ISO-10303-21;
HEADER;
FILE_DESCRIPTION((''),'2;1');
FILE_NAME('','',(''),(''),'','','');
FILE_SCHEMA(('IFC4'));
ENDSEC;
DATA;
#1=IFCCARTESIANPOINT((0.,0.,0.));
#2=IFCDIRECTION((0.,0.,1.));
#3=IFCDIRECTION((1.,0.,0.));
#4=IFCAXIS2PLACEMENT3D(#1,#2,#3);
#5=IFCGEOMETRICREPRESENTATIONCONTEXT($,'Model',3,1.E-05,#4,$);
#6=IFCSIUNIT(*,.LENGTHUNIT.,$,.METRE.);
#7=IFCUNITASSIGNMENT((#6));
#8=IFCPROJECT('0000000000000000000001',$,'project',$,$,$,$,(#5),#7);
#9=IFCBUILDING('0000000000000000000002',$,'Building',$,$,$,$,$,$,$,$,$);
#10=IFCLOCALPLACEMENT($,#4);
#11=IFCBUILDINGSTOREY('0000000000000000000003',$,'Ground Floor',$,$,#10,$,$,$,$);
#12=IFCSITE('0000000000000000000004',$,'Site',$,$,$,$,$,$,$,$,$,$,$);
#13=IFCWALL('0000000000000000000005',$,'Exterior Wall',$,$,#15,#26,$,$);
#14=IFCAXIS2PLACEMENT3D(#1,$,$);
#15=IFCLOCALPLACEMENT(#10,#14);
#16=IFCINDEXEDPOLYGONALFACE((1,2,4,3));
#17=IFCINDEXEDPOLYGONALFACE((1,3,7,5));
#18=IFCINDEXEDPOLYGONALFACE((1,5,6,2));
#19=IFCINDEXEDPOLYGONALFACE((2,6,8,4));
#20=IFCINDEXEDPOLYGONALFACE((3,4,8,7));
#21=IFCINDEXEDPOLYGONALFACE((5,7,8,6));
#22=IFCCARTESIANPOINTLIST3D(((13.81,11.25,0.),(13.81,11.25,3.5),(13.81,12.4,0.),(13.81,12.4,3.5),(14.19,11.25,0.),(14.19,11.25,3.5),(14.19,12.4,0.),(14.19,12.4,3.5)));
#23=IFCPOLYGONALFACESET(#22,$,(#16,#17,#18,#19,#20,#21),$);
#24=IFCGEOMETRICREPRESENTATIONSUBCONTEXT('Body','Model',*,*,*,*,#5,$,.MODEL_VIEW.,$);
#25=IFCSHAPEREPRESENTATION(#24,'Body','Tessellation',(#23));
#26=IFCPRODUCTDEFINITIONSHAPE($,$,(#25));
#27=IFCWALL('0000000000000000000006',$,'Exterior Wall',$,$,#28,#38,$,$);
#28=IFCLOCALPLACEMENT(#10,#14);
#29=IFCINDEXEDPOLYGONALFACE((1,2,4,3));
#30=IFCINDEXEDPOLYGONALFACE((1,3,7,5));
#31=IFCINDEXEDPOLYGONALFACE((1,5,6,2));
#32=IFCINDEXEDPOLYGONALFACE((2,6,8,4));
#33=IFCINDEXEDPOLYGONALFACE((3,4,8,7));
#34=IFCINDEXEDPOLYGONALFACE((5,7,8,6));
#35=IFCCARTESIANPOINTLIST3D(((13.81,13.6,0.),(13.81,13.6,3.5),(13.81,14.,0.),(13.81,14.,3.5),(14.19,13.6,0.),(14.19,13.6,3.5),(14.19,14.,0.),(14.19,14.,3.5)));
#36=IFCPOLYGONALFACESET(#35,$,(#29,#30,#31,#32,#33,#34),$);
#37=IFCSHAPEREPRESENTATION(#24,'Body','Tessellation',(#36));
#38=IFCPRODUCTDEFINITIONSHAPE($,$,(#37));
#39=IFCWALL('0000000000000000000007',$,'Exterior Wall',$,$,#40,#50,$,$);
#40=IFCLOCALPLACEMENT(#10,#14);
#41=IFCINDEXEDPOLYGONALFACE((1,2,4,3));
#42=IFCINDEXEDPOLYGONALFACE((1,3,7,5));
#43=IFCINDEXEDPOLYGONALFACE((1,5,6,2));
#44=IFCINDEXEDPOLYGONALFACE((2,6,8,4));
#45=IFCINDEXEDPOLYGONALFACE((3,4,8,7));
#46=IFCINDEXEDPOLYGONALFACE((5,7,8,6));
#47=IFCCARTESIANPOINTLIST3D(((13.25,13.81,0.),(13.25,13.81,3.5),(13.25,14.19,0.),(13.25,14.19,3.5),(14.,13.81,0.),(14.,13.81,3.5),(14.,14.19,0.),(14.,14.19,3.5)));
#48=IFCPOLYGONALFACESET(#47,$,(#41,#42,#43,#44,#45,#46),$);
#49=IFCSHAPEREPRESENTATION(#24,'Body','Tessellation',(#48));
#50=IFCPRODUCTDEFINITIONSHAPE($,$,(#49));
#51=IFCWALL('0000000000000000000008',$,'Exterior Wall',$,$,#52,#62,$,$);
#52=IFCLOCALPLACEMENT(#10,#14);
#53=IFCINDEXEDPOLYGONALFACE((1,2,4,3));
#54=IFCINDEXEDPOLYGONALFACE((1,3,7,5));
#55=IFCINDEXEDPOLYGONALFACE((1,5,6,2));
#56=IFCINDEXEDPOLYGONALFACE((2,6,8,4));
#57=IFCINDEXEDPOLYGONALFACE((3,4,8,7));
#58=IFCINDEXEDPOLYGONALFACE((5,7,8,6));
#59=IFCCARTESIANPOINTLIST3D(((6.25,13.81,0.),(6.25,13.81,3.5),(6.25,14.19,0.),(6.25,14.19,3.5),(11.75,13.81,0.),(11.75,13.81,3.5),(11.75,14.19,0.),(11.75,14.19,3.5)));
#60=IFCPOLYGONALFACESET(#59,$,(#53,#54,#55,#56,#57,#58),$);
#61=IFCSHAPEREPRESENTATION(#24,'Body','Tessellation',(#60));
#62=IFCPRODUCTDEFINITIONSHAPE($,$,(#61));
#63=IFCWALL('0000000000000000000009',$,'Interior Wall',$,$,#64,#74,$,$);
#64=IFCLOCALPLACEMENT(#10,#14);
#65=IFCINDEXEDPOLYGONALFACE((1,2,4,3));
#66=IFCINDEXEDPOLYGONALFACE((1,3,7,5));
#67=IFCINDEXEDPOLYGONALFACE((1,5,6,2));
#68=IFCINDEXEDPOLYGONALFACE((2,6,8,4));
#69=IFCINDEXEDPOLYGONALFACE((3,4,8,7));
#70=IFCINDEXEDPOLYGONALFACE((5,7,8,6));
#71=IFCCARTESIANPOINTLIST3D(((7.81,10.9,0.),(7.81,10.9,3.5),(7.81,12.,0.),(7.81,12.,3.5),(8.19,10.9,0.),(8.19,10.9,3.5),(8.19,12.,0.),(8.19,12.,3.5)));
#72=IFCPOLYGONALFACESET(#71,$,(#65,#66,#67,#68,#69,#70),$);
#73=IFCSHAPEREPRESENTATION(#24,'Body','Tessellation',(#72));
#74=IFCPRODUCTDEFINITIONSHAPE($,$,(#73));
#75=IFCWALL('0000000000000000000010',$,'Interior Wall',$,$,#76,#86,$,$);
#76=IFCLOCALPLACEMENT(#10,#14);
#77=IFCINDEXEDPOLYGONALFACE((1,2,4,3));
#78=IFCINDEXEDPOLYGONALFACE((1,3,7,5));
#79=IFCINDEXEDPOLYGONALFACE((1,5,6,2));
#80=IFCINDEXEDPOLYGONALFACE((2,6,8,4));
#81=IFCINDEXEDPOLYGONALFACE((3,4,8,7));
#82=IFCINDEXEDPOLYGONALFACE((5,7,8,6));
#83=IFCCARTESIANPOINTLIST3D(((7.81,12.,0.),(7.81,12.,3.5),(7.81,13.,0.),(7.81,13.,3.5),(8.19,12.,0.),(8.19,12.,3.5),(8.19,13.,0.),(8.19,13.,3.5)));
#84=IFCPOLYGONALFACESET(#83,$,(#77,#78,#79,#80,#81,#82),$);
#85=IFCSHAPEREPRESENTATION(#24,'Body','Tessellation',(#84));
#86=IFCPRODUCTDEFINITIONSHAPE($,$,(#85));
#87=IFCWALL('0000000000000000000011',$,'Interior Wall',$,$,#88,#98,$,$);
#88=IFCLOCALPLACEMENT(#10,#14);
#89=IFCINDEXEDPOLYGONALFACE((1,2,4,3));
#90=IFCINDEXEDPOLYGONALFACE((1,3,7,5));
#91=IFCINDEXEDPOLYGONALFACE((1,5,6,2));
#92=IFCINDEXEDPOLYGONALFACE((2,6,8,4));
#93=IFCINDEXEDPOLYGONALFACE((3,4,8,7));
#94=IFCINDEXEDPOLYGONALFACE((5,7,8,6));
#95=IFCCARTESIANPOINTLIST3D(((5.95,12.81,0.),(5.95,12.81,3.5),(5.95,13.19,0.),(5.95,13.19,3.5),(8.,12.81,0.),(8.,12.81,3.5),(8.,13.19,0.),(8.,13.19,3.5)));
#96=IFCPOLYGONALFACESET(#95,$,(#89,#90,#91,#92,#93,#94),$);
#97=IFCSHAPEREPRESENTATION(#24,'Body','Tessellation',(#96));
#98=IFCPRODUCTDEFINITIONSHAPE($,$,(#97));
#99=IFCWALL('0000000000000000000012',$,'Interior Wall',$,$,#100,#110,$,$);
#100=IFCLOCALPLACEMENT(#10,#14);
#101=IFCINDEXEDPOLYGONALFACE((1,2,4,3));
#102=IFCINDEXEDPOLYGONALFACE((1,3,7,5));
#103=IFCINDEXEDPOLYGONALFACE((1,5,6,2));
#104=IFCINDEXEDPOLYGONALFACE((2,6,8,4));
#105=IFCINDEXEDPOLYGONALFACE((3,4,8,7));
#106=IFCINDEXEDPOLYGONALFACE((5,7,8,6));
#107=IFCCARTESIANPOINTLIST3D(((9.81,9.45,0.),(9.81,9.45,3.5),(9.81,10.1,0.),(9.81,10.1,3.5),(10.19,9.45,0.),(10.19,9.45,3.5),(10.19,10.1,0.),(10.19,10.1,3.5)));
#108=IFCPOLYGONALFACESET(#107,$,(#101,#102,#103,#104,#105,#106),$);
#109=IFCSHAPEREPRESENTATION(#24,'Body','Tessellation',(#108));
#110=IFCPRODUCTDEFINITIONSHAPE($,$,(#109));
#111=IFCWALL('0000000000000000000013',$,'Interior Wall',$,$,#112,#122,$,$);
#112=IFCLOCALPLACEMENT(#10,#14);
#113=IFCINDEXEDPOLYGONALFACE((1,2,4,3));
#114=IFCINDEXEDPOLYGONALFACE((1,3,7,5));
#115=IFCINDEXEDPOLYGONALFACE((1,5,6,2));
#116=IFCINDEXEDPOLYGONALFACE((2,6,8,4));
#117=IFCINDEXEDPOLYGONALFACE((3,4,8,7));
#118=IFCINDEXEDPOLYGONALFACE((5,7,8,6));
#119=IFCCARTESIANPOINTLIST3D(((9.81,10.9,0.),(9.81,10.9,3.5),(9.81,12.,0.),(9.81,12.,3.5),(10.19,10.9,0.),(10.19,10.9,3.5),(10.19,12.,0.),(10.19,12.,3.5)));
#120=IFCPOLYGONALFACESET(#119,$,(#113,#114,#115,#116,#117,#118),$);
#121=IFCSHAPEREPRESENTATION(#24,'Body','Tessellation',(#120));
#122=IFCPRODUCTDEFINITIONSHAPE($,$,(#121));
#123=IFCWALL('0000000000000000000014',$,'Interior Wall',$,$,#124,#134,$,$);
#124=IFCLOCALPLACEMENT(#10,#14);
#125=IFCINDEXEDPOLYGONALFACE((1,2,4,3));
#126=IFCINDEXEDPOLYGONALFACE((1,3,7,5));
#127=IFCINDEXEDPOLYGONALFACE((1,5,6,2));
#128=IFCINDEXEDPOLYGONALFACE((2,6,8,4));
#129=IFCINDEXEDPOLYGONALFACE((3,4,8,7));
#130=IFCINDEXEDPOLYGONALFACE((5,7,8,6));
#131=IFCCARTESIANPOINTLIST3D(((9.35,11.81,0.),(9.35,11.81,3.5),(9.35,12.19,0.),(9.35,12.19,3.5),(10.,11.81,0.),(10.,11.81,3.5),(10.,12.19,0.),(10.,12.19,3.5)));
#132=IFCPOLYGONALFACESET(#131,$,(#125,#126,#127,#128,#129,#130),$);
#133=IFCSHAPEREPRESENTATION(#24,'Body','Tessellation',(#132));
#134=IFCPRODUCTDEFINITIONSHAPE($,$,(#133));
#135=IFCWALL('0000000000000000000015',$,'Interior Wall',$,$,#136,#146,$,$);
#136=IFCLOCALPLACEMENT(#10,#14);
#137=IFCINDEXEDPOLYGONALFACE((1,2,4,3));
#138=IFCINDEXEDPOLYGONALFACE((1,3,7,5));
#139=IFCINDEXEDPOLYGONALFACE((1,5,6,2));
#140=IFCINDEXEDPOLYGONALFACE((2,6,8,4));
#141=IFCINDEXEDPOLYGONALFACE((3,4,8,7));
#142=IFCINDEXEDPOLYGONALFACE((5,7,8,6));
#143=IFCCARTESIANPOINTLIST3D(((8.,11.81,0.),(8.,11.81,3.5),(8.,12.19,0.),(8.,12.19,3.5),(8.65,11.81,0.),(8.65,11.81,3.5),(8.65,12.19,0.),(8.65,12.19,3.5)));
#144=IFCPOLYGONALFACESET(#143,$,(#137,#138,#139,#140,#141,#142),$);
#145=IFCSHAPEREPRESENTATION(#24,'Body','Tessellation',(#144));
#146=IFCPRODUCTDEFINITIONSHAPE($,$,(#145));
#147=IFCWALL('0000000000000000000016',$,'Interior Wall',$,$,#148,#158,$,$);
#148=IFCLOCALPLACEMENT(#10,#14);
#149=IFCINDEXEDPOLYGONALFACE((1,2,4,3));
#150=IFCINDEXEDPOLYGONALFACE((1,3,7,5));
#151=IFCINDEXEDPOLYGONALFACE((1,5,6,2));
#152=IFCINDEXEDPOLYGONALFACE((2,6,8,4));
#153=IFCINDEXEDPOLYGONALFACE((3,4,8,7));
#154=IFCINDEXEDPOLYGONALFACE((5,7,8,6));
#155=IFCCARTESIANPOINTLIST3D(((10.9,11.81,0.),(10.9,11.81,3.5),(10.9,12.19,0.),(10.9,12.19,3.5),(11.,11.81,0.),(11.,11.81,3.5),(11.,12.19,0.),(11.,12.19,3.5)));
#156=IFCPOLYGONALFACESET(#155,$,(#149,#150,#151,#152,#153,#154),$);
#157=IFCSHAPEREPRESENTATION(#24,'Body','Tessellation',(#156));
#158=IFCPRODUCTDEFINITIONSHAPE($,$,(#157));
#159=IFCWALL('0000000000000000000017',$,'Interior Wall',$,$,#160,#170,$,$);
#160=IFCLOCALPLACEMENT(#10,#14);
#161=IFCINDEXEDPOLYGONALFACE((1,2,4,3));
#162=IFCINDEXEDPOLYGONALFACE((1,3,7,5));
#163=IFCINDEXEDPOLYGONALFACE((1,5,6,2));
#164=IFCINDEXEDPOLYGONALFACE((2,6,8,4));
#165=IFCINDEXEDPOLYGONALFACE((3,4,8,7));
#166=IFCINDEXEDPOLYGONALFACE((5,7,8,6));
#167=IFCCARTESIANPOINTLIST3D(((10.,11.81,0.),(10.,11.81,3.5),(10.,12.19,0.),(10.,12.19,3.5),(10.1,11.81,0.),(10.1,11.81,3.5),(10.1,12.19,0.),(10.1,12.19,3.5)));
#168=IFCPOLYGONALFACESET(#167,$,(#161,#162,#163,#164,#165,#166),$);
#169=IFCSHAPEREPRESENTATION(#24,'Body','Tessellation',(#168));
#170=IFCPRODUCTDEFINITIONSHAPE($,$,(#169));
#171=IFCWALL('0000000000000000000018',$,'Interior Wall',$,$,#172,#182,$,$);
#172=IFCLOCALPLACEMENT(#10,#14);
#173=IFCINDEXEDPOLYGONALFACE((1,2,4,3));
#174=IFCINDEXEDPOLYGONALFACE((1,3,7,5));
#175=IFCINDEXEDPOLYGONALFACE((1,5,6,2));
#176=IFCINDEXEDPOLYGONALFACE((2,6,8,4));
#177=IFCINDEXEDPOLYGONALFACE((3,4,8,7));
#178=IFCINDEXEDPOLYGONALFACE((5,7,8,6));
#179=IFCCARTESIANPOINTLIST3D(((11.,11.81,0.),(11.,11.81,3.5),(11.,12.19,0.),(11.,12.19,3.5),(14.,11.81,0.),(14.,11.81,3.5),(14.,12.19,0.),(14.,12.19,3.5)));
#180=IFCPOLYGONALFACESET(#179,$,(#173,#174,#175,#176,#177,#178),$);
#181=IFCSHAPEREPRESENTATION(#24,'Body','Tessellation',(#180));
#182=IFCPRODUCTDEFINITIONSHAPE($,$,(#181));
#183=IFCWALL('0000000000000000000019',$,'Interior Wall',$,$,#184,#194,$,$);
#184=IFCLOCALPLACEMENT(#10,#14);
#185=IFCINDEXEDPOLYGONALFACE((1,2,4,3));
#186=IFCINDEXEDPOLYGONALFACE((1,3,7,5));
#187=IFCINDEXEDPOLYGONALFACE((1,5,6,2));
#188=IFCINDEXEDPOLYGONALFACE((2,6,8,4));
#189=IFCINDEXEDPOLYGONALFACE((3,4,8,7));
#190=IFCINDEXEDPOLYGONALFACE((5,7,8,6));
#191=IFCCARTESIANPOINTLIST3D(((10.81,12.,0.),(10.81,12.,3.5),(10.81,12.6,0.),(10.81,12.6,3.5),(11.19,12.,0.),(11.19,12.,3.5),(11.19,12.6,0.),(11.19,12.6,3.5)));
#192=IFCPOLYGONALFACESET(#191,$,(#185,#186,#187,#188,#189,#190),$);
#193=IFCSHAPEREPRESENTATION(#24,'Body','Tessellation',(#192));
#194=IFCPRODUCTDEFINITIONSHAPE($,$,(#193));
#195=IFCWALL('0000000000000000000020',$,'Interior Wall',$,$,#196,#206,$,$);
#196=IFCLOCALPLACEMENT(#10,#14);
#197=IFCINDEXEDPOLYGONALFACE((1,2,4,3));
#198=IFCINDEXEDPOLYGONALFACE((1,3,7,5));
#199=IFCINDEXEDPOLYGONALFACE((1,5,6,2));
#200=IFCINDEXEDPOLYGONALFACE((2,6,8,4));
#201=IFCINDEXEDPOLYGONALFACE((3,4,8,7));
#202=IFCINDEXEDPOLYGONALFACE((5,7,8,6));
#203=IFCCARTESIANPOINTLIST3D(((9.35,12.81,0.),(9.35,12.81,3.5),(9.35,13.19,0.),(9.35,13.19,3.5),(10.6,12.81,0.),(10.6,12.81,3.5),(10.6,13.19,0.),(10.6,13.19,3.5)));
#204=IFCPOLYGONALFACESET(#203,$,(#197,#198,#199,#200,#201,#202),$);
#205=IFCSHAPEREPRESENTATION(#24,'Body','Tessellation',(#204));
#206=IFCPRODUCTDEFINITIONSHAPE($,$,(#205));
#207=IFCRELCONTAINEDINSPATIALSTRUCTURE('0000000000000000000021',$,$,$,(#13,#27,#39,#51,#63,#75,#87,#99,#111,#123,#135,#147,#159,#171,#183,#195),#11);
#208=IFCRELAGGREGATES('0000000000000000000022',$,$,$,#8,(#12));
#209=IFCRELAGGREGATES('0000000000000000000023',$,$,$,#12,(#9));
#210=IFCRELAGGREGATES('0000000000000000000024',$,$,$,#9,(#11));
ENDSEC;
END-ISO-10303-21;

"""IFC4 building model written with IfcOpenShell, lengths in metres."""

from ifc_helpers import new_model, si_unit, frame, origin_with_axes, place, context, subcontext, project, spatial, indexed_curve, outline, extrude, element, save


model = new_model("IFC4")

# Units and contexts
model_context = context("Model", 3, precision=1e-05, world=origin_with_axes())
body_context = subcontext(model_context, "Body", "Model", "MODEL_VIEW")
ifc_project = project(units=[si_unit("LENGTHUNIT", "METRE")], contexts=[model_context])

# Site, building, storey
site = spatial("IfcSite", under=ifc_project, Name="Site")
building = spatial("IfcBuilding", under=site, Name="Building")
storey_placement = place(None, origin_with_axes())
storey = spatial("IfcBuildingStorey", under=building, at=storey_placement, Name="Ground Floor")

# Walls
wall_1_placement = place(storey_placement, frame((14.0, 11.25, 0.0), z_axis=(0.0, 0.0, 1.0), x_axis=(0.0, 1.0, 0.0)))
element("IfcWall", 1, at=wall_1_placement, inside=storey, Name="Exterior Wall", context=body_context, shape_type="SweptSolid", body=[
    extrude(outline(indexed_curve([(0.0, 0.0), (0.0, 0.38), (1.15, 0.38), (1.15, 0.0), (0.0, 0.0)], self_intersect=False)), frame((0.0, -0.19, 0.0), z_axis=(0.0, 0.0, 1.0), x_axis=(1.0, 0.0, 0.0)), (0.0, 0.0, 1.0), 3.5),
])
wall_2_placement = place(storey_placement, frame((14.0, 13.6, 0.0), z_axis=(0.0, 0.0, 1.0), x_axis=(0.0, 1.0, 0.0)))
element("IfcWall", 2, at=wall_2_placement, inside=storey, Name="Exterior Wall", context=body_context, shape_type="SweptSolid", body=[
    extrude(outline(indexed_curve([(0.0, 0.0), (0.0, 0.38), (0.4, 0.38), (0.4, 0.0), (0.0, 0.0)], self_intersect=False)), frame((0.0, -0.19, 0.0), z_axis=(0.0, 0.0, 1.0), x_axis=(1.0, 0.0, 0.0)), (0.0, 0.0, 1.0), 3.5),
])
wall_3_placement = place(storey_placement, frame((14.0, 14.0, 0.0), z_axis=(0.0, 0.0, 1.0), x_axis=(-1.0, 0.0, 0.0)))
element("IfcWall", 3, at=wall_3_placement, inside=storey, Name="Exterior Wall", context=body_context, shape_type="SweptSolid", body=[
    extrude(outline(indexed_curve([(0.0, 0.0), (0.0, 0.38), (0.75, 0.38), (0.75, 0.0), (0.0, 0.0)], self_intersect=False)), frame((0.0, -0.19, 0.0), z_axis=(0.0, 0.0, 1.0), x_axis=(1.0, 0.0, 0.0)), (0.0, 0.0, 1.0), 3.5),
])
wall_4_placement = place(storey_placement, frame((11.75, 14.0, 0.0), z_axis=(0.0, 0.0, 1.0), x_axis=(-1.0, 0.0, 0.0)))
element("IfcWall", 4, at=wall_4_placement, inside=storey, Name="Exterior Wall", context=body_context, shape_type="SweptSolid", body=[
    extrude(outline(indexed_curve([(0.0, 0.0), (0.0, 0.38), (5.5, 0.38), (5.5, 0.0), (0.0, 0.0)], self_intersect=False)), frame((0.0, -0.19, 0.0), z_axis=(0.0, 0.0, 1.0), x_axis=(1.0, 0.0, 0.0)), (0.0, 0.0, 1.0), 3.5),
])
wall_5_placement = place(storey_placement, frame((8.0, 10.9, 0.0), z_axis=(0.0, 0.0, 1.0), x_axis=(0.0, 1.0, 0.0)))
element("IfcWall", 5, at=wall_5_placement, inside=storey, Name="Interior Wall", context=body_context, shape_type="SweptSolid", body=[
    extrude(outline(indexed_curve([(0.0, 0.0), (0.0, 0.38), (1.1, 0.38), (1.1, 0.0), (0.0, 0.0)], self_intersect=False)), frame((0.0, -0.19, 0.0), z_axis=(0.0, 0.0, 1.0), x_axis=(1.0, 0.0, 0.0)), (0.0, 0.0, 1.0), 3.5),
])
wall_6_placement = place(storey_placement, frame((8.0, 12.0, 0.0), z_axis=(0.0, 0.0, 1.0), x_axis=(0.0, 1.0, 0.0)))
element("IfcWall", 6, at=wall_6_placement, inside=storey, Name="Interior Wall", context=body_context, shape_type="SweptSolid", body=[
    extrude(outline(indexed_curve([(0.0, 0.0), (0.0, 0.38), (1.0, 0.38), (1.0, 0.0), (0.0, 0.0)], self_intersect=False)), frame((0.0, -0.19, 0.0), z_axis=(0.0, 0.0, 1.0), x_axis=(1.0, 0.0, 0.0)), (0.0, 0.0, 1.0), 3.5),
])
wall_7_placement = place(storey_placement, frame((8.0, 13.0, 0.0), z_axis=(0.0, 0.0, 1.0), x_axis=(-1.0, 0.0, 0.0)))
element("IfcWall", 7, at=wall_7_placement, inside=storey, Name="Interior Wall", context=body_context, shape_type="SweptSolid", body=[
    extrude(outline(indexed_curve([(0.0, 0.0), (0.0, 0.38), (2.05, 0.38), (2.05, 0.0), (0.0, 0.0)], self_intersect=False)), frame((0.0, -0.19, 0.0), z_axis=(0.0, 0.0, 1.0), x_axis=(1.0, 0.0, 0.0)), (0.0, 0.0, 1.0), 3.5),
])
wall_8_placement = place(storey_placement, frame((10.0, 9.45, 0.0), z_axis=(0.0, 0.0, 1.0), x_axis=(0.0, 1.0, 0.0)))
element("IfcWall", 8, at=wall_8_placement, inside=storey, Name="Interior Wall", context=body_context, shape_type="SweptSolid", body=[
    extrude(outline(indexed_curve([(0.0, 0.0), (0.0, 0.38), (0.65, 0.38), (0.65, 0.0), (0.0, 0.0)], self_intersect=False)), frame((0.0, -0.19, 0.0), z_axis=(0.0, 0.0, 1.0), x_axis=(1.0, 0.0, 0.0)), (0.0, 0.0, 1.0), 3.5),
])
wall_9_placement = place(storey_placement, frame((10.0, 10.9, 0.0), z_axis=(0.0, 0.0, 1.0), x_axis=(0.0, 1.0, 0.0)))
element("IfcWall", 9, at=wall_9_placement, inside=storey, Name="Interior Wall", context=body_context, shape_type="SweptSolid", body=[
    extrude(outline(indexed_curve([(0.0, 0.0), (0.0, 0.38), (1.1, 0.38), (1.1, 0.0), (0.0, 0.0)], self_intersect=False)), frame((0.0, -0.19, 0.0), z_axis=(0.0, 0.0, 1.0), x_axis=(1.0, 0.0, 0.0)), (0.0, 0.0, 1.0), 3.5),
])
for number, where, z_axis, x_axis, name in (
    (10, (10.0, 12.0, 0.0), (0.0, 0.0, 1.0), (-1.0, 0.0, 0.0), "Interior Wall"),
    (11, (8.65, 12.0, 0.0), (0.0, 0.0, 1.0), (-1.0, 0.0, 0.0), "Interior Wall"),
):
    element("IfcWall", number, at=place(storey_placement, frame(where, z_axis=z_axis, x_axis=x_axis)), inside=storey, Name=name, context=body_context, shape_type="SweptSolid", body=[
        extrude(outline(indexed_curve([(0.0, 0.0), (0.0, 0.38), (0.65, 0.38), (0.65, 0.0), (0.0, 0.0)], self_intersect=False)), frame((0.0, -0.19, 0.0), z_axis=(0.0, 0.0, 1.0), x_axis=(1.0, 0.0, 0.0)), (0.0, 0.0, 1.0), 3.5),
    ])
for number, where, z_axis, x_axis, name in (
    (12, (11.0, 12.0, 0.0), (0.0, 0.0, 1.0), (-1.0, 0.0, 0.0), "Interior Wall"),
    (13, (10.1, 12.0, 0.0), (0.0, 0.0, 1.0), (-1.0, 0.0, 0.0), "Interior Wall"),
):
    element("IfcWall", number, at=place(storey_placement, frame(where, z_axis=z_axis, x_axis=x_axis)), inside=storey, Name=name, context=body_context, shape_type="SweptSolid", body=[
        extrude(outline(indexed_curve([(0.0, 0.0), (0.0, 0.38), (0.1, 0.38), (0.1, 0.0), (0.0, 0.0)], self_intersect=False)), frame((0.0, -0.19, 0.0), z_axis=(0.0, 0.0, 1.0), x_axis=(1.0, 0.0, 0.0)), (0.0, 0.0, 1.0), 3.5),
    ])
wall_10_placement = place(storey_placement, frame((14.0, 12.0, 0.0), z_axis=(0.0, 0.0, 1.0), x_axis=(-1.0, 0.0, 0.0)))
element("IfcWall", 14, at=wall_10_placement, inside=storey, Name="Interior Wall", context=body_context, shape_type="SweptSolid", body=[
    extrude(outline(indexed_curve([(0.0, 0.0), (0.0, 0.38), (3.0, 0.38), (3.0, 0.0), (0.0, 0.0)], self_intersect=False)), frame((0.0, -0.19, 0.0), z_axis=(0.0, 0.0, 1.0), x_axis=(1.0, 0.0, 0.0)), (0.0, 0.0, 1.0), 3.5),
])
wall_11_placement = place(storey_placement, frame((11.0, 12.0, 0.0), z_axis=(0.0, 0.0, 1.0), x_axis=(0.0, 1.0, 0.0)))
element("IfcWall", 15, at=wall_11_placement, inside=storey, Name="Interior Wall", context=body_context, shape_type="SweptSolid", body=[
    extrude(outline(indexed_curve([(0.0, 0.0), (0.0, 0.38), (0.6, 0.38), (0.6, 0.0), (0.0, 0.0)], self_intersect=False)), frame((0.0, -0.19, 0.0), z_axis=(0.0, 0.0, 1.0), x_axis=(1.0, 0.0, 0.0)), (0.0, 0.0, 1.0), 3.5),
])
wall_12_placement = place(storey_placement, frame((10.6, 13.0, 0.0), z_axis=(0.0, 0.0, 1.0), x_axis=(-1.0, 0.0, 0.0)))
element("IfcWall", 16, at=wall_12_placement, inside=storey, Name="Interior Wall", context=body_context, shape_type="SweptSolid", body=[
    extrude(outline(indexed_curve([(0.0, 0.0), (0.0, 0.38), (1.25, 0.38), (1.25, 0.0), (0.0, 0.0)], self_intersect=False)), frame((0.0, -0.19, 0.0), z_axis=(0.0, 0.0, 1.0), x_axis=(1.0, 0.0, 0.0)), (0.0, 0.0, 1.0), 3.5),
])

save(model, "model.ifc")
